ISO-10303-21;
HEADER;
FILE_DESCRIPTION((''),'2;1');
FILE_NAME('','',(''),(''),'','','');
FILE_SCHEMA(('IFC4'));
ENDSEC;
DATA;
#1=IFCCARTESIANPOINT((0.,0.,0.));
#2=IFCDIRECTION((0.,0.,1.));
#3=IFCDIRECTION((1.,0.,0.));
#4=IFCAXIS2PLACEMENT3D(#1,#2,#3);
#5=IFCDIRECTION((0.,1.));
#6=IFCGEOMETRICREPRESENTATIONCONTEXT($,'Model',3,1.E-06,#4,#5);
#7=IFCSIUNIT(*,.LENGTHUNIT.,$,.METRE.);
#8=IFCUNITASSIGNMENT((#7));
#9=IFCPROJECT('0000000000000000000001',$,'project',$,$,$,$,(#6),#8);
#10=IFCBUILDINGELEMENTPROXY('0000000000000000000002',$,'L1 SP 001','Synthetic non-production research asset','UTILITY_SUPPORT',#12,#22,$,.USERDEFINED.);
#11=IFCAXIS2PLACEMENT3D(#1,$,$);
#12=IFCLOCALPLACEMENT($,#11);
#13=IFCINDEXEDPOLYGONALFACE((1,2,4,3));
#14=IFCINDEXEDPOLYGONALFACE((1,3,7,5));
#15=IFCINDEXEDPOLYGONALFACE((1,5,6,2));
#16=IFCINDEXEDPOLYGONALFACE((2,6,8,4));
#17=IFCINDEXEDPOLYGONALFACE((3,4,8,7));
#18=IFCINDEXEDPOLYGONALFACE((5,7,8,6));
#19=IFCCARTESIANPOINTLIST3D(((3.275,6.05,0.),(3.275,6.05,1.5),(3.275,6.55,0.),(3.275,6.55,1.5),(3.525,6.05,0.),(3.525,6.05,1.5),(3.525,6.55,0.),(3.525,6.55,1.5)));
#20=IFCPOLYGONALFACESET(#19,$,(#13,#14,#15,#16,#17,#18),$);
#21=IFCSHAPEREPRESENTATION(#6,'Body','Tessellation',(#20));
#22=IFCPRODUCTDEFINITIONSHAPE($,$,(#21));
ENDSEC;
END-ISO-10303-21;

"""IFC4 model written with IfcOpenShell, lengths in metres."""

from ifc_helpers import new_model, si_unit, direction, frame, origin_with_axes, origin_2d_with_axis, place, context, project, rectangle, extrude, element, save


model = new_model("IFC4")

# Units and contexts
model_context = context("Model", 3, precision=1e-06, world=origin_with_axes(), true_north=direction((0.0, 1.0)))
ifc_project = project(units=[si_unit("LENGTHUNIT", "METRE")], contexts=[model_context])

# Building element proxy
proxy_placement = place(None, frame((3.4, 6.3, 0.0), z_axis=(0.0, 0.0, 1.0), x_axis=(1.0, 0.0, 0.0)))
element("IfcBuildingElementProxy", 1, at=proxy_placement, Name="L1 SP 001", Description="Synthetic non-production research asset", ObjectType="UTILITY_SUPPORT", PredefinedType="USERDEFINED", context=model_context, shape_type="SweptSolid", body=[
    extrude(rectangle(XDim=0.25, YDim=0.5, at=origin_2d_with_axis()), origin_with_axes(), (0.0, 0.0, 1.0), 1.5),
])

save(model, "model.ifc")
